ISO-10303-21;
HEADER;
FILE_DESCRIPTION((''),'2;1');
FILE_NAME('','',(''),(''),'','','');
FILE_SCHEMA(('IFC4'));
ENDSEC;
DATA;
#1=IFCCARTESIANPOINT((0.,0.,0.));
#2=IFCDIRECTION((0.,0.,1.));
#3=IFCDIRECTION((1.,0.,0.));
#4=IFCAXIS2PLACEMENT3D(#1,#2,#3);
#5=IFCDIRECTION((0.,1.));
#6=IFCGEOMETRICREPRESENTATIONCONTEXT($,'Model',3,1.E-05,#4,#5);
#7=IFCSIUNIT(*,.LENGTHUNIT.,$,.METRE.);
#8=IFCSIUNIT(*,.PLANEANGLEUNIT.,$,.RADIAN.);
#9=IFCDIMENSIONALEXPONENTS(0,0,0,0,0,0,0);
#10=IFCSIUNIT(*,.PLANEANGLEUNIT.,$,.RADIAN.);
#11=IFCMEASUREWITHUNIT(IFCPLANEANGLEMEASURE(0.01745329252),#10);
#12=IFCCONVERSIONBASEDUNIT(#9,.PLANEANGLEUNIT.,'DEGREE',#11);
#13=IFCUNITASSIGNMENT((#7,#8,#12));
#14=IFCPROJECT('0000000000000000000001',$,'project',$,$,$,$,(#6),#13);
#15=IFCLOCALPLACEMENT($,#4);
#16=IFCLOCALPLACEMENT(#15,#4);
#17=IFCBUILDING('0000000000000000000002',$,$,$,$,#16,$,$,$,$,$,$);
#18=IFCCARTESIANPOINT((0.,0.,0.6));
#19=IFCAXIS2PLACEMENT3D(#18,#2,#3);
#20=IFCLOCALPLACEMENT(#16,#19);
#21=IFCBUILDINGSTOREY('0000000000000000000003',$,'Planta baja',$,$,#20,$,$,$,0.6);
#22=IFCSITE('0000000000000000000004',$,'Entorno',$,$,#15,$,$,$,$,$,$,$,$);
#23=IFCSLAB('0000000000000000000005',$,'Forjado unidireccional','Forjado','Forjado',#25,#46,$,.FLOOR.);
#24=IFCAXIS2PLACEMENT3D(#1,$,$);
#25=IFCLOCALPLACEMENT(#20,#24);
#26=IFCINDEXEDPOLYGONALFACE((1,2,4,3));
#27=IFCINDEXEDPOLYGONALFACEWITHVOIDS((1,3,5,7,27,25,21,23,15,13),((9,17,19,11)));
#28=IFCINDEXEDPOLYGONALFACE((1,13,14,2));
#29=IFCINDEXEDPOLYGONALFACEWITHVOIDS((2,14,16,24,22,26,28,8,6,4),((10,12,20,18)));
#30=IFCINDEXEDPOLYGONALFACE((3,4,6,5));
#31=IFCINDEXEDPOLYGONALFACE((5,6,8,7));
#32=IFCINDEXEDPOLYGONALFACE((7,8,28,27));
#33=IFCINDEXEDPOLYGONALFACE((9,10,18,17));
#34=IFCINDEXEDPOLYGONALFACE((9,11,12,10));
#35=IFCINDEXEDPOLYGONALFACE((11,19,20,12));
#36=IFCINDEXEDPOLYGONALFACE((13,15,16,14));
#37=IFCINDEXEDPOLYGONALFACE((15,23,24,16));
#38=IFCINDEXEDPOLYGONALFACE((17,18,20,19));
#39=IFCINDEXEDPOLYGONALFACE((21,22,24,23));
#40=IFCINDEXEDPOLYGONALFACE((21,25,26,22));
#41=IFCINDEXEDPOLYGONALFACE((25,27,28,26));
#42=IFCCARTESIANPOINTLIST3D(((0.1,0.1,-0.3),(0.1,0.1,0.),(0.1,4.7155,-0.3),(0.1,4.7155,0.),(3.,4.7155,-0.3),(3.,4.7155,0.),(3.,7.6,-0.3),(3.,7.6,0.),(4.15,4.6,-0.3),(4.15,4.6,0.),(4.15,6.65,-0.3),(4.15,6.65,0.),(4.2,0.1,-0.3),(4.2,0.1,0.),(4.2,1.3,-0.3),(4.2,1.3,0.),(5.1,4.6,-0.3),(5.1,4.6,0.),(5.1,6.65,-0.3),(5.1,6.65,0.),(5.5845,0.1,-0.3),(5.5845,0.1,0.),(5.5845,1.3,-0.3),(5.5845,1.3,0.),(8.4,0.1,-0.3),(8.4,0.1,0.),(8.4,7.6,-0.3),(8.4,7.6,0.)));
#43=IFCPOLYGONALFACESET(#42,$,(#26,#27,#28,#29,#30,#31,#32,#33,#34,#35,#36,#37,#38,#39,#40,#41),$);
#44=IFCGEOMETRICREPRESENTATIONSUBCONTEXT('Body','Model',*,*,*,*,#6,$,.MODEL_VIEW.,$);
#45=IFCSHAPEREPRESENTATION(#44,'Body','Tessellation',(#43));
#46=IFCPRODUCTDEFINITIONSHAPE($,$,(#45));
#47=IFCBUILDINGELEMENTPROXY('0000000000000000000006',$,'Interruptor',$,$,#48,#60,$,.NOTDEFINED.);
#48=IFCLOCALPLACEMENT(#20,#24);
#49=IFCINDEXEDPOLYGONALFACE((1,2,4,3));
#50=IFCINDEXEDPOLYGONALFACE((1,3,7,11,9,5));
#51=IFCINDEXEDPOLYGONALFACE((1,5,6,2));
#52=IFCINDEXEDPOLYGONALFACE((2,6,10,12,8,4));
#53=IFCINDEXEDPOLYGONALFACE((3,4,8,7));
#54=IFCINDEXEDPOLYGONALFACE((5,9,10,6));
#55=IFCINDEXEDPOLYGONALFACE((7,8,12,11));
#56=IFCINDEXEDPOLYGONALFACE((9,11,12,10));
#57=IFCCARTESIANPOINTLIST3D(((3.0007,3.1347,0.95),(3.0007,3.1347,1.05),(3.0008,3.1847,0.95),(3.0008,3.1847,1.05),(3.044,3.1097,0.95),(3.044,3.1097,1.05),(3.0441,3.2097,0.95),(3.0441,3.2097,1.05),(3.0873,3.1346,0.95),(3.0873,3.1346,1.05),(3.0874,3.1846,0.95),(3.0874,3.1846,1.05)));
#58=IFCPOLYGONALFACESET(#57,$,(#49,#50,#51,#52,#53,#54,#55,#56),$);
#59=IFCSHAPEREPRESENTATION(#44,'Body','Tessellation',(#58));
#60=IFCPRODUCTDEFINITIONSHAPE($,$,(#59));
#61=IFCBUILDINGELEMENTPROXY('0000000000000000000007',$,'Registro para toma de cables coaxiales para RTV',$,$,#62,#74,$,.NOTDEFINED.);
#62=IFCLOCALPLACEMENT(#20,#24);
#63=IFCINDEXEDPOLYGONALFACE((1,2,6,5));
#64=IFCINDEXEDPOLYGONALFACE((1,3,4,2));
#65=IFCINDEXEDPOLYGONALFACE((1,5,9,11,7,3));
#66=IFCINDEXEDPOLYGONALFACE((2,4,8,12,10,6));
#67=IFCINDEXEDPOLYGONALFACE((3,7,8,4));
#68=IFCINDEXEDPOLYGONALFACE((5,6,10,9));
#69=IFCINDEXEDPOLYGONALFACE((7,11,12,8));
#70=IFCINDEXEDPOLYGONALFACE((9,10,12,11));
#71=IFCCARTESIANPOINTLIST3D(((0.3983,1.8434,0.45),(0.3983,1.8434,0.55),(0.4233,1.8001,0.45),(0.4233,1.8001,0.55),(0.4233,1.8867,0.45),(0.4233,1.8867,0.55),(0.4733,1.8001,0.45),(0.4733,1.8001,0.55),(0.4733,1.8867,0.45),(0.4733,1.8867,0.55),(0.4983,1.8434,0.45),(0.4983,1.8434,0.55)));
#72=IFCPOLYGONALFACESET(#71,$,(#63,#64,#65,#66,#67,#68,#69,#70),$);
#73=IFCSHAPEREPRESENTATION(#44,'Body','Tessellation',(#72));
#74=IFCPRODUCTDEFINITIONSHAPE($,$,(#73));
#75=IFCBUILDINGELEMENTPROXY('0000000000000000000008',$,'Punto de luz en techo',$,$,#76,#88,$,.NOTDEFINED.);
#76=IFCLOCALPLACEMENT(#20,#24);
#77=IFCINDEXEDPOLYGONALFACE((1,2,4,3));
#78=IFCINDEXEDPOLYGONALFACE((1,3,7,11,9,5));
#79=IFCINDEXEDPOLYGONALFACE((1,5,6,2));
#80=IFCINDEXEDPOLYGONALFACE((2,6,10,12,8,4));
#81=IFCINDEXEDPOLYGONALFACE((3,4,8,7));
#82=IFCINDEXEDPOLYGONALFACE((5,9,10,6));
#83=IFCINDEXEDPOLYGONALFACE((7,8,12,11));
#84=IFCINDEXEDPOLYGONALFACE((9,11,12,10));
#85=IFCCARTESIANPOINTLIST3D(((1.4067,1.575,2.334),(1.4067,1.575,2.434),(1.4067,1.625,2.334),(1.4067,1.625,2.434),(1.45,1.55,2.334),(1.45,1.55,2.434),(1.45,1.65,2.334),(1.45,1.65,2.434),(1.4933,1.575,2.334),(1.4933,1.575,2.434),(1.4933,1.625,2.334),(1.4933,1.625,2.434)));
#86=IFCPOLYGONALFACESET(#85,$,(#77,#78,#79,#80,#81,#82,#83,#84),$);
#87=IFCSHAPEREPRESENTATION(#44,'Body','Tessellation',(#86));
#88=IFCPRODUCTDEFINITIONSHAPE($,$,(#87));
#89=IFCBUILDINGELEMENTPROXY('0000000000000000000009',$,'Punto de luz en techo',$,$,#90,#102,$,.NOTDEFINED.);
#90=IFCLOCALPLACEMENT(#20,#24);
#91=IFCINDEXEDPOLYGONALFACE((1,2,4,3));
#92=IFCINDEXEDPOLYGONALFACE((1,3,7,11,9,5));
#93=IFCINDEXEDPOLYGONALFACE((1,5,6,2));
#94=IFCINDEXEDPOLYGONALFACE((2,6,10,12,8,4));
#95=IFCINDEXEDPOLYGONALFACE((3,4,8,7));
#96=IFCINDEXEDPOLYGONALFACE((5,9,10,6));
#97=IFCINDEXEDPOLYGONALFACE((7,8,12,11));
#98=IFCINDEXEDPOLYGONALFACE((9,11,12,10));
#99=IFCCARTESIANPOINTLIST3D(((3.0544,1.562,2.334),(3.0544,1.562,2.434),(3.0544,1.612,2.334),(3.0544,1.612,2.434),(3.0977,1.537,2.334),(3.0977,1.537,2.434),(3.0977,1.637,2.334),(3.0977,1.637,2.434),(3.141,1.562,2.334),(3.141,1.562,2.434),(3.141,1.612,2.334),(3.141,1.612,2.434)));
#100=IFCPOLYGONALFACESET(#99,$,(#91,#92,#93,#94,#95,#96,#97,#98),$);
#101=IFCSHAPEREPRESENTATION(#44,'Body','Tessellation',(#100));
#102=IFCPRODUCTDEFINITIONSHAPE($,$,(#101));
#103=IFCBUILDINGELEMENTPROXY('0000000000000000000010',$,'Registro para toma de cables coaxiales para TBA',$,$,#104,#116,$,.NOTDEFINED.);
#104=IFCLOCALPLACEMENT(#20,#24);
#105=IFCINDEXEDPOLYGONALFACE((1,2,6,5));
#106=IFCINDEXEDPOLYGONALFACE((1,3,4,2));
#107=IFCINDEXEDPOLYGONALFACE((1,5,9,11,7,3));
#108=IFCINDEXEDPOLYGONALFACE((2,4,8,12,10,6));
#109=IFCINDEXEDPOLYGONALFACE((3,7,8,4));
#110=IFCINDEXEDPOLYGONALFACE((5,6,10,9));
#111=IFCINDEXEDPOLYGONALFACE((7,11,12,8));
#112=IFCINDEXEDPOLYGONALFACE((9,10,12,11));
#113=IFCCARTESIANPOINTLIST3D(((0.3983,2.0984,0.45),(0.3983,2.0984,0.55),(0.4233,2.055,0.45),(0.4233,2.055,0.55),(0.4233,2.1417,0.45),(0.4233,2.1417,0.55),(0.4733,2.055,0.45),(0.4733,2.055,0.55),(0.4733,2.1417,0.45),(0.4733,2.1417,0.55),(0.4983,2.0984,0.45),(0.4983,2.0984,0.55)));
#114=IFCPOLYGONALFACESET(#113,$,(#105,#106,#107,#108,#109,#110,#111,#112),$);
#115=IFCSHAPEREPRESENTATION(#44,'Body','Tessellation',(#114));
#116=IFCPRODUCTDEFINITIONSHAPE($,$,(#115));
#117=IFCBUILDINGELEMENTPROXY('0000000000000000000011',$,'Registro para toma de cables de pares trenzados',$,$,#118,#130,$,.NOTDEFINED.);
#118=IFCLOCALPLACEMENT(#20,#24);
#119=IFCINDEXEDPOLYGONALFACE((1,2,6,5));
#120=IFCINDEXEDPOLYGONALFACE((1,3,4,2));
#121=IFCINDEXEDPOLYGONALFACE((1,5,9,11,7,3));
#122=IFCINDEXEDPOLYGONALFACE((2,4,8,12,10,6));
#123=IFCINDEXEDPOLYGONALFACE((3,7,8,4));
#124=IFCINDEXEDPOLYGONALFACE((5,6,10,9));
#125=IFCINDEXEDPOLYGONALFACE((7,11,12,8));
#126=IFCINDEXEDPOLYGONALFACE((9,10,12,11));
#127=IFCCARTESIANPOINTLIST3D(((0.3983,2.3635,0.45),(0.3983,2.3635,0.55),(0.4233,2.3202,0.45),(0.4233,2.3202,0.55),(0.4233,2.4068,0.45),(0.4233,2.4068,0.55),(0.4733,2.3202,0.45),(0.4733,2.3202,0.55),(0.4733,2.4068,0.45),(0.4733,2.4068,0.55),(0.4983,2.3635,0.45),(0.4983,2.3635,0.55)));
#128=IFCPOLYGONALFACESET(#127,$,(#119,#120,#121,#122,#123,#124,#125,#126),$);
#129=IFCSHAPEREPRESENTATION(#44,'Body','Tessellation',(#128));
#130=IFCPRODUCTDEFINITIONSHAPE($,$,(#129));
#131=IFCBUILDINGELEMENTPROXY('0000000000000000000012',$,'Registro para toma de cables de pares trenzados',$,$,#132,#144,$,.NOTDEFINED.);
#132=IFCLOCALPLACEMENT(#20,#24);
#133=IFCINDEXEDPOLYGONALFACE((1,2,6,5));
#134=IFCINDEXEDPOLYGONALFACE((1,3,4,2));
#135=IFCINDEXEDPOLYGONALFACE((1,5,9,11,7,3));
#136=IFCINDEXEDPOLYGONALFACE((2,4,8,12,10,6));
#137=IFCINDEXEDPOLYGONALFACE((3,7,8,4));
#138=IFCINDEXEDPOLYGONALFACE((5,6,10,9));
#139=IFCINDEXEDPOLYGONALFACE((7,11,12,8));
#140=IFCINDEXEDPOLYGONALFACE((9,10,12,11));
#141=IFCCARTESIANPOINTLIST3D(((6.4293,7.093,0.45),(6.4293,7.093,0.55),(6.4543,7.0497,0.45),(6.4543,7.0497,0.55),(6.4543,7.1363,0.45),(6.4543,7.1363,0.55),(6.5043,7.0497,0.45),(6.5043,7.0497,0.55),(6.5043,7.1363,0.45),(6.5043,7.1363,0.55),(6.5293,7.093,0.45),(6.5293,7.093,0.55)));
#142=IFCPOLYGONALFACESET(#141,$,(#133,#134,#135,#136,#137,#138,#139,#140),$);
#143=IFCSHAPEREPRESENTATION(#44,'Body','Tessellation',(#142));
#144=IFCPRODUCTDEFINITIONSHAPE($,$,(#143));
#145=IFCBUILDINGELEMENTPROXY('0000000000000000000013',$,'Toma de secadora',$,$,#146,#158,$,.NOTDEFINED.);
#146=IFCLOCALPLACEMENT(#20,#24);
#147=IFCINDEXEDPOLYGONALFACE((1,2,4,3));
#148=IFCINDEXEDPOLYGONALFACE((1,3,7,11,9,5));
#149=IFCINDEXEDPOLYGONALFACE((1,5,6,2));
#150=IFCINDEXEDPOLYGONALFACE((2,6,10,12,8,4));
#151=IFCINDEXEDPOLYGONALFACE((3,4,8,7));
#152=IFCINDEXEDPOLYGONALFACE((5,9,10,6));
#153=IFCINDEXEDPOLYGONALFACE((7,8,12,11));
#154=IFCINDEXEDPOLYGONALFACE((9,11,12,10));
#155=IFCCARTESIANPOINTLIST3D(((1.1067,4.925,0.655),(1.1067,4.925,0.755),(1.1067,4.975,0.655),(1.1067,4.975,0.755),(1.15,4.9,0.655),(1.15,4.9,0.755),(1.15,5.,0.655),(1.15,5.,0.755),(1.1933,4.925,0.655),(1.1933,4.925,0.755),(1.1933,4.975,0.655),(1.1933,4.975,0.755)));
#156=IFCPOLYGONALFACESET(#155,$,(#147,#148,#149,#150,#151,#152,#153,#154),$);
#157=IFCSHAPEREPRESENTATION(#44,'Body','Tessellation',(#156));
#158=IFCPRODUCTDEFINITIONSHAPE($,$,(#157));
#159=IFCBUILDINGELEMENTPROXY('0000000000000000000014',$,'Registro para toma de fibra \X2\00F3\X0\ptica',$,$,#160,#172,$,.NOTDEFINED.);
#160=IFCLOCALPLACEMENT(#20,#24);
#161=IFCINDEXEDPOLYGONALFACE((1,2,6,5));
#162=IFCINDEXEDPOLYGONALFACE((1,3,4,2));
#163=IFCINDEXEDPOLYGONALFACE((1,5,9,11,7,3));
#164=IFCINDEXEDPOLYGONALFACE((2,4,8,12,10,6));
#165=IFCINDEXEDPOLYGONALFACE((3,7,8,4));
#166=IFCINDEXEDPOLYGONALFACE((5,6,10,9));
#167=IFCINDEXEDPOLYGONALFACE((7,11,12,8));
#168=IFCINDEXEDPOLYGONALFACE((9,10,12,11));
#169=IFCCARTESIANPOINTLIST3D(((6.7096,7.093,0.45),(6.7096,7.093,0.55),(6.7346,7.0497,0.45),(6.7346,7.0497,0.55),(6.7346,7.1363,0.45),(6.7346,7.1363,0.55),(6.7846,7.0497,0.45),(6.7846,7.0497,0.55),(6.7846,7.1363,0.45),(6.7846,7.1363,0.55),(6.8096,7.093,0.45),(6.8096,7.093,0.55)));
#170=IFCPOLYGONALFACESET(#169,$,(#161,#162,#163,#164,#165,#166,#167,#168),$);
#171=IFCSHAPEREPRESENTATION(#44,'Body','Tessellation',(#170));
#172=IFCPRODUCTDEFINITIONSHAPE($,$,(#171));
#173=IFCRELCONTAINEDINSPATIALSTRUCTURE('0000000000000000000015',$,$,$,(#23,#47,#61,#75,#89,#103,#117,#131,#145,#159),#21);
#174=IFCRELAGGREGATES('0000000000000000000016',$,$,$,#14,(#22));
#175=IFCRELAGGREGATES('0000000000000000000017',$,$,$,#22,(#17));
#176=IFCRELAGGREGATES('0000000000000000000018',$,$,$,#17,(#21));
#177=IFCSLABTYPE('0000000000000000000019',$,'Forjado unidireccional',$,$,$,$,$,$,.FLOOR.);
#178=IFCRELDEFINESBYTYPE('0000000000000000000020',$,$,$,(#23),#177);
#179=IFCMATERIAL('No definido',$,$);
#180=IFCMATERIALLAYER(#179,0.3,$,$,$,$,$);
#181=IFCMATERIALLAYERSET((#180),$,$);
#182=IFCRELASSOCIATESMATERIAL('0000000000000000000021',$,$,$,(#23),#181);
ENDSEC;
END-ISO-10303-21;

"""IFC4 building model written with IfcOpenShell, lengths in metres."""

from ifc_helpers import new_model, entity, si_unit, converted_unit, direction, frame, origin_with_axes, place, context, subcontext, project, spatial, polyline, outline, extrude, source, transform, mapped, material, layer, layer_set, layer_usage, type_object, element, save


model = new_model("IFC4")

# Units and contexts
model_context = context("Model", 3, precision=1e-05, world=origin_with_axes(), true_north=direction((0.0, 1.0)))
body_context = subcontext(model_context, "Body", "Model", "MODEL_VIEW")
ifc_project = project(units=[si_unit("LENGTHUNIT", "METRE"), si_unit("PLANEANGLEUNIT", "RADIAN"), converted_unit("PLANEANGLEUNIT", "DEGREE", entity("IfcPlaneAngleMeasure", 0.01745329252), si_unit("PLANEANGLEUNIT", "RADIAN"), dimensions=[0, 0, 0, 0, 0, 0, 0])], contexts=[model_context])

# Site, building, storey
site_placement = place(None, origin_with_axes())
site = spatial("IfcSite", under=ifc_project, at=site_placement, Name="Entorno")
building_placement = place(site_placement, origin_with_axes())
building = spatial("IfcBuilding", under=site, at=building_placement)
storey_placement = place(building_placement, frame((0.0, 0.0, 0.6), z_axis=(0.0, 0.0, 1.0), x_axis=(1.0, 0.0, 0.0)))
storey = spatial("IfcBuildingStorey", under=building, at=storey_placement, Name="Planta baja", Elevation=0.6)

# Slab, opening
ifc_material = material(Name="No definido")
ifc_layer = layer(ifc_material, 0.3)
ifc_layer_set = layer_set([ifc_layer])
ifc_layer_usage = layer_usage(ifc_layer_set, "AXIS3", "POSITIVE", 0.0)
slab_type = type_object("IfcSlabType", Name="Forjado unidireccional", PredefinedType="FLOOR")
slab_placement = place(storey_placement, frame((4.2, 0.1, -0.3), z_axis=(0.0, 0.0, 1.0), x_axis=(1.0, 0.0, 0.0)))
slab = element("IfcSlab", 1, at=slab_placement, inside=storey, type_object=slab_type, material=ifc_layer_usage, Name="Forjado unidireccional", Description="Forjado", ObjectType="Forjado", PredefinedType="FLOOR", context=body_context, shape_type="SweptSolid", body=[
    extrude(outline(polyline([(0.0, 0.0), (0.0, 1.2), (1.3845, 1.2), (1.3845, 0.0), (4.2, 0.0), (4.2, 7.5), (-1.2, 7.5), (-1.2, 4.6155), (-4.1, 4.6155), (-4.1, 0.0), (0.0, 0.0)])), origin_with_axes(), (0.0, 0.0, 1.0), 0.3),
])
opening_placement = place(slab_placement, frame((-0.05, 4.5, -0.01), z_axis=(0.0, 0.0, 1.0), x_axis=(1.0, 0.0, 0.0)))
element("IfcOpeningElement", 2, at=opening_placement, cuts=slab, ObjectType="No definido", PredefinedType="OPENING", context=body_context, shape_type="SweptSolid", body=[
    extrude(outline(polyline([(0.0, 0.0), (0.95, 0.0), (0.95, 2.05), (0.0, 2.05), (0.0, 0.0)])), origin_with_axes(), (0.0, 0.0, 1.0), 0.32),
])

# Building element proxies
shared_shape_1 = source(origin_with_axes(), body_context, "Body", "SolidModel", [
    extrude(outline(polyline([(0.05, 0.0), (0.025, 0.0433), (-0.025, 0.0433), (-0.05, 0.0), (-0.025, -0.0433), (0.025, -0.0433), (0.05, 0.0)])), frame((0.0, 0.0, -0.05), z_axis=(0.0, 0.0, 1.0), x_axis=(1.0, 0.0, 0.0)), (0.0, 0.0, 1.0), 0.1),
])
proxy_1_placement = place(storey_placement, frame((0.0, 0.0, -0.6), z_axis=(0.0, 0.0, 1.0), x_axis=(1.0, 0.0, 0.0)))
element("IfcBuildingElementProxy", 3, at=proxy_1_placement, inside=storey, Name="Interruptor", PredefinedType="NOTDEFINED", context=body_context, shape_type="Brep", body=[
    mapped(shared_shape_1, transform((3.0441, 3.1597, 1.6), x_axis=(-0.001016, -0.999999, 0.0), y_axis=(0.999999, -0.001016, 0.0), z_axis=(0.0, 0.0, 1.0))),
])
shared_shape_2 = source(origin_with_axes(), body_context, "Body", "SolidModel", [
    extrude(outline(polyline([(0.05, 0.0), (0.025, 0.0433), (-0.025, 0.0433), (-0.05, 0.0), (-0.025, -0.0433), (0.025, -0.0433), (0.05, 0.0)])), frame((0.0, 0.0, -0.05), z_axis=(0.0, 0.0, 1.0), x_axis=(1.0, 0.0, 0.0)), (0.0, 0.0, 1.0), 0.1),
])
proxy_2_placement = place(storey_placement, frame((0.0, 0.0, -0.6), z_axis=(0.0, 0.0, 1.0), x_axis=(1.0, 0.0, 0.0)))
element("IfcBuildingElementProxy", 4, at=proxy_2_placement, inside=storey, Name="Registro para toma de cables coaxiales para RTV", PredefinedType="NOTDEFINED", context=body_context, shape_type="Brep", body=[
    mapped(shared_shape_2, transform((0.4483, 1.8434, 1.1), x_axis=(1.0, 0.0, 0.0), y_axis=(0.0, 1.0, 0.0), z_axis=(0.0, 0.0, 1.0))),
])
shared_shape_3 = source(origin_with_axes(), body_context, "Body", "SolidModel", [
    extrude(outline(polyline([(0.05, 0.0), (0.025, 0.0433), (-0.025, 0.0433), (-0.05, 0.0), (-0.025, -0.0433), (0.025, -0.0433), (0.05, 0.0)])), frame((0.0, 0.0, -0.05), z_axis=(0.0, 0.0, 1.0), x_axis=(1.0, 0.0, 0.0)), (0.0, 0.0, 1.0), 0.1),
])
proxy_3_placement = place(storey_placement, frame((0.0, 0.0, -0.6), z_axis=(0.0, 0.0, 1.0), x_axis=(1.0, 0.0, 0.0)))
element("IfcBuildingElementProxy", 5, at=proxy_3_placement, inside=storey, Name="Punto de luz en techo", PredefinedType="NOTDEFINED", context=body_context, shape_type="Brep", body=[
    mapped(shared_shape_3, transform((1.45, 1.6, 2.984), x_axis=(0.0, -1.0, 0.0), y_axis=(1.0, 0.0, 0.0), z_axis=(0.0, 0.0, 1.0))),
])
proxy_4_placement = place(storey_placement, frame((0.0, 0.0, -0.6), z_axis=(0.0, 0.0, 1.0), x_axis=(1.0, 0.0, 0.0)))
element("IfcBuildingElementProxy", 6, at=proxy_4_placement, inside=storey, Name="Punto de luz en techo", PredefinedType="NOTDEFINED", context=body_context, shape_type="Brep", body=[
    mapped(shared_shape_3, transform((3.0977, 1.587, 2.984), x_axis=(0.0, -1.0, 0.0), y_axis=(1.0, 0.0, 0.0), z_axis=(0.0, 0.0, 1.0))),
])
shared_shape_4 = source(origin_with_axes(), body_context, "Body", "SolidModel", [
    extrude(outline(polyline([(0.05, 0.0), (0.025, 0.0433), (-0.025, 0.0433), (-0.05, 0.0), (-0.025, -0.0433), (0.025, -0.0433), (0.05, 0.0)])), frame((0.0, 0.0, -0.05), z_axis=(0.0, 0.0, 1.0), x_axis=(1.0, 0.0, 0.0)), (0.0, 0.0, 1.0), 0.1),
])
proxy_5_placement = place(storey_placement, frame((0.0, 0.0, -0.6), z_axis=(0.0, 0.0, 1.0), x_axis=(1.0, 0.0, 0.0)))
element("IfcBuildingElementProxy", 7, at=proxy_5_placement, inside=storey, Name="Registro para toma de cables coaxiales para TBA", PredefinedType="NOTDEFINED", context=body_context, shape_type="Brep", body=[
    mapped(shared_shape_4, transform((0.4483, 2.0984, 1.1), x_axis=(1.0, 0.0, 0.0), y_axis=(0.0, 1.0, 0.0), z_axis=(0.0, 0.0, 1.0))),
])
shared_shape_5 = source(origin_with_axes(), body_context, "Body", "SolidModel", [
    extrude(outline(polyline([(0.05, 0.0), (0.025, 0.0433), (-0.025, 0.0433), (-0.05, 0.0), (-0.025, -0.0433), (0.025, -0.0433), (0.05, 0.0)])), frame((0.0, 0.0, -0.05), z_axis=(0.0, 0.0, 1.0), x_axis=(1.0, 0.0, 0.0)), (0.0, 0.0, 1.0), 0.1),
])
proxy_6_placement = place(storey_placement, frame((0.0, 0.0, -0.6), z_axis=(0.0, 0.0, 1.0), x_axis=(1.0, 0.0, 0.0)))
element("IfcBuildingElementProxy", 8, at=proxy_6_placement, inside=storey, Name="Registro para toma de cables de pares trenzados", PredefinedType="NOTDEFINED", context=body_context, shape_type="Brep", body=[
    mapped(shared_shape_5, transform((0.4483, 2.3635, 1.1), x_axis=(1.0, 0.0, 0.0), y_axis=(0.0, 1.0, 0.0), z_axis=(0.0, 0.0, 1.0))),
])
proxy_7_placement = place(storey_placement, frame((0.0, 0.0, -0.6), z_axis=(0.0, 0.0, 1.0), x_axis=(1.0, 0.0, 0.0)))
element("IfcBuildingElementProxy", 9, at=proxy_7_placement, inside=storey, Name="Registro para toma de cables de pares trenzados", PredefinedType="NOTDEFINED", context=body_context, shape_type="Brep", body=[
    mapped(shared_shape_5, transform((6.4793, 7.093, 1.1), x_axis=(1.0, 0.0, 0.0), y_axis=(0.0, 1.0, 0.0), z_axis=(0.0, 0.0, 1.0))),
])
shared_shape_6 = source(origin_with_axes(), body_context, "Body", "SolidModel", [
    extrude(outline(polyline([(0.05, 0.0), (0.025, 0.0433), (-0.025, 0.0433), (-0.05, 0.0), (-0.025, -0.0433), (0.025, -0.0433), (0.05, 0.0)])), frame((0.0, 0.0, -0.05), z_axis=(0.0, 0.0, 1.0), x_axis=(1.0, 0.0, 0.0)), (0.0, 0.0, 1.0), 0.1),
])
proxy_8_placement = place(storey_placement, frame((0.0, 0.0, -0.6), z_axis=(0.0, 0.0, 1.0), x_axis=(1.0, 0.0, 0.0)))
element("IfcBuildingElementProxy", 10, at=proxy_8_placement, inside=storey, Name="Toma de secadora", PredefinedType="NOTDEFINED", context=body_context, shape_type="Brep", body=[
    mapped(shared_shape_6, transform((1.15, 4.95, 1.305), x_axis=(0.0, -1.0, 0.0), y_axis=(1.0, 0.0, 0.0), z_axis=(0.0, 0.0, 1.0))),
])
shared_shape_7 = source(origin_with_axes(), body_context, "Body", "SolidModel", [
    extrude(outline(polyline([(0.05, 0.0), (0.025, 0.0433), (-0.025, 0.0433), (-0.05, 0.0), (-0.025, -0.0433), (0.025, -0.0433), (0.05, 0.0)])), frame((0.0, 0.0, -0.05), z_axis=(0.0, 0.0, 1.0), x_axis=(1.0, 0.0, 0.0)), (0.0, 0.0, 1.0), 0.1),
])
proxy_9_placement = place(storey_placement, frame((0.0, 0.0, -0.6), z_axis=(0.0, 0.0, 1.0), x_axis=(1.0, 0.0, 0.0)))
element("IfcBuildingElementProxy", 11, at=proxy_9_placement, inside=storey, Name="Registro para toma de fibra óptica", PredefinedType="NOTDEFINED", context=body_context, shape_type="Brep", body=[
    mapped(shared_shape_7, transform((6.7596, 7.093, 1.1), x_axis=(1.0, 0.0, 0.0), y_axis=(0.0, 1.0, 0.0), z_axis=(0.0, 0.0, 1.0))),
])

save(model, "model.ifc")
